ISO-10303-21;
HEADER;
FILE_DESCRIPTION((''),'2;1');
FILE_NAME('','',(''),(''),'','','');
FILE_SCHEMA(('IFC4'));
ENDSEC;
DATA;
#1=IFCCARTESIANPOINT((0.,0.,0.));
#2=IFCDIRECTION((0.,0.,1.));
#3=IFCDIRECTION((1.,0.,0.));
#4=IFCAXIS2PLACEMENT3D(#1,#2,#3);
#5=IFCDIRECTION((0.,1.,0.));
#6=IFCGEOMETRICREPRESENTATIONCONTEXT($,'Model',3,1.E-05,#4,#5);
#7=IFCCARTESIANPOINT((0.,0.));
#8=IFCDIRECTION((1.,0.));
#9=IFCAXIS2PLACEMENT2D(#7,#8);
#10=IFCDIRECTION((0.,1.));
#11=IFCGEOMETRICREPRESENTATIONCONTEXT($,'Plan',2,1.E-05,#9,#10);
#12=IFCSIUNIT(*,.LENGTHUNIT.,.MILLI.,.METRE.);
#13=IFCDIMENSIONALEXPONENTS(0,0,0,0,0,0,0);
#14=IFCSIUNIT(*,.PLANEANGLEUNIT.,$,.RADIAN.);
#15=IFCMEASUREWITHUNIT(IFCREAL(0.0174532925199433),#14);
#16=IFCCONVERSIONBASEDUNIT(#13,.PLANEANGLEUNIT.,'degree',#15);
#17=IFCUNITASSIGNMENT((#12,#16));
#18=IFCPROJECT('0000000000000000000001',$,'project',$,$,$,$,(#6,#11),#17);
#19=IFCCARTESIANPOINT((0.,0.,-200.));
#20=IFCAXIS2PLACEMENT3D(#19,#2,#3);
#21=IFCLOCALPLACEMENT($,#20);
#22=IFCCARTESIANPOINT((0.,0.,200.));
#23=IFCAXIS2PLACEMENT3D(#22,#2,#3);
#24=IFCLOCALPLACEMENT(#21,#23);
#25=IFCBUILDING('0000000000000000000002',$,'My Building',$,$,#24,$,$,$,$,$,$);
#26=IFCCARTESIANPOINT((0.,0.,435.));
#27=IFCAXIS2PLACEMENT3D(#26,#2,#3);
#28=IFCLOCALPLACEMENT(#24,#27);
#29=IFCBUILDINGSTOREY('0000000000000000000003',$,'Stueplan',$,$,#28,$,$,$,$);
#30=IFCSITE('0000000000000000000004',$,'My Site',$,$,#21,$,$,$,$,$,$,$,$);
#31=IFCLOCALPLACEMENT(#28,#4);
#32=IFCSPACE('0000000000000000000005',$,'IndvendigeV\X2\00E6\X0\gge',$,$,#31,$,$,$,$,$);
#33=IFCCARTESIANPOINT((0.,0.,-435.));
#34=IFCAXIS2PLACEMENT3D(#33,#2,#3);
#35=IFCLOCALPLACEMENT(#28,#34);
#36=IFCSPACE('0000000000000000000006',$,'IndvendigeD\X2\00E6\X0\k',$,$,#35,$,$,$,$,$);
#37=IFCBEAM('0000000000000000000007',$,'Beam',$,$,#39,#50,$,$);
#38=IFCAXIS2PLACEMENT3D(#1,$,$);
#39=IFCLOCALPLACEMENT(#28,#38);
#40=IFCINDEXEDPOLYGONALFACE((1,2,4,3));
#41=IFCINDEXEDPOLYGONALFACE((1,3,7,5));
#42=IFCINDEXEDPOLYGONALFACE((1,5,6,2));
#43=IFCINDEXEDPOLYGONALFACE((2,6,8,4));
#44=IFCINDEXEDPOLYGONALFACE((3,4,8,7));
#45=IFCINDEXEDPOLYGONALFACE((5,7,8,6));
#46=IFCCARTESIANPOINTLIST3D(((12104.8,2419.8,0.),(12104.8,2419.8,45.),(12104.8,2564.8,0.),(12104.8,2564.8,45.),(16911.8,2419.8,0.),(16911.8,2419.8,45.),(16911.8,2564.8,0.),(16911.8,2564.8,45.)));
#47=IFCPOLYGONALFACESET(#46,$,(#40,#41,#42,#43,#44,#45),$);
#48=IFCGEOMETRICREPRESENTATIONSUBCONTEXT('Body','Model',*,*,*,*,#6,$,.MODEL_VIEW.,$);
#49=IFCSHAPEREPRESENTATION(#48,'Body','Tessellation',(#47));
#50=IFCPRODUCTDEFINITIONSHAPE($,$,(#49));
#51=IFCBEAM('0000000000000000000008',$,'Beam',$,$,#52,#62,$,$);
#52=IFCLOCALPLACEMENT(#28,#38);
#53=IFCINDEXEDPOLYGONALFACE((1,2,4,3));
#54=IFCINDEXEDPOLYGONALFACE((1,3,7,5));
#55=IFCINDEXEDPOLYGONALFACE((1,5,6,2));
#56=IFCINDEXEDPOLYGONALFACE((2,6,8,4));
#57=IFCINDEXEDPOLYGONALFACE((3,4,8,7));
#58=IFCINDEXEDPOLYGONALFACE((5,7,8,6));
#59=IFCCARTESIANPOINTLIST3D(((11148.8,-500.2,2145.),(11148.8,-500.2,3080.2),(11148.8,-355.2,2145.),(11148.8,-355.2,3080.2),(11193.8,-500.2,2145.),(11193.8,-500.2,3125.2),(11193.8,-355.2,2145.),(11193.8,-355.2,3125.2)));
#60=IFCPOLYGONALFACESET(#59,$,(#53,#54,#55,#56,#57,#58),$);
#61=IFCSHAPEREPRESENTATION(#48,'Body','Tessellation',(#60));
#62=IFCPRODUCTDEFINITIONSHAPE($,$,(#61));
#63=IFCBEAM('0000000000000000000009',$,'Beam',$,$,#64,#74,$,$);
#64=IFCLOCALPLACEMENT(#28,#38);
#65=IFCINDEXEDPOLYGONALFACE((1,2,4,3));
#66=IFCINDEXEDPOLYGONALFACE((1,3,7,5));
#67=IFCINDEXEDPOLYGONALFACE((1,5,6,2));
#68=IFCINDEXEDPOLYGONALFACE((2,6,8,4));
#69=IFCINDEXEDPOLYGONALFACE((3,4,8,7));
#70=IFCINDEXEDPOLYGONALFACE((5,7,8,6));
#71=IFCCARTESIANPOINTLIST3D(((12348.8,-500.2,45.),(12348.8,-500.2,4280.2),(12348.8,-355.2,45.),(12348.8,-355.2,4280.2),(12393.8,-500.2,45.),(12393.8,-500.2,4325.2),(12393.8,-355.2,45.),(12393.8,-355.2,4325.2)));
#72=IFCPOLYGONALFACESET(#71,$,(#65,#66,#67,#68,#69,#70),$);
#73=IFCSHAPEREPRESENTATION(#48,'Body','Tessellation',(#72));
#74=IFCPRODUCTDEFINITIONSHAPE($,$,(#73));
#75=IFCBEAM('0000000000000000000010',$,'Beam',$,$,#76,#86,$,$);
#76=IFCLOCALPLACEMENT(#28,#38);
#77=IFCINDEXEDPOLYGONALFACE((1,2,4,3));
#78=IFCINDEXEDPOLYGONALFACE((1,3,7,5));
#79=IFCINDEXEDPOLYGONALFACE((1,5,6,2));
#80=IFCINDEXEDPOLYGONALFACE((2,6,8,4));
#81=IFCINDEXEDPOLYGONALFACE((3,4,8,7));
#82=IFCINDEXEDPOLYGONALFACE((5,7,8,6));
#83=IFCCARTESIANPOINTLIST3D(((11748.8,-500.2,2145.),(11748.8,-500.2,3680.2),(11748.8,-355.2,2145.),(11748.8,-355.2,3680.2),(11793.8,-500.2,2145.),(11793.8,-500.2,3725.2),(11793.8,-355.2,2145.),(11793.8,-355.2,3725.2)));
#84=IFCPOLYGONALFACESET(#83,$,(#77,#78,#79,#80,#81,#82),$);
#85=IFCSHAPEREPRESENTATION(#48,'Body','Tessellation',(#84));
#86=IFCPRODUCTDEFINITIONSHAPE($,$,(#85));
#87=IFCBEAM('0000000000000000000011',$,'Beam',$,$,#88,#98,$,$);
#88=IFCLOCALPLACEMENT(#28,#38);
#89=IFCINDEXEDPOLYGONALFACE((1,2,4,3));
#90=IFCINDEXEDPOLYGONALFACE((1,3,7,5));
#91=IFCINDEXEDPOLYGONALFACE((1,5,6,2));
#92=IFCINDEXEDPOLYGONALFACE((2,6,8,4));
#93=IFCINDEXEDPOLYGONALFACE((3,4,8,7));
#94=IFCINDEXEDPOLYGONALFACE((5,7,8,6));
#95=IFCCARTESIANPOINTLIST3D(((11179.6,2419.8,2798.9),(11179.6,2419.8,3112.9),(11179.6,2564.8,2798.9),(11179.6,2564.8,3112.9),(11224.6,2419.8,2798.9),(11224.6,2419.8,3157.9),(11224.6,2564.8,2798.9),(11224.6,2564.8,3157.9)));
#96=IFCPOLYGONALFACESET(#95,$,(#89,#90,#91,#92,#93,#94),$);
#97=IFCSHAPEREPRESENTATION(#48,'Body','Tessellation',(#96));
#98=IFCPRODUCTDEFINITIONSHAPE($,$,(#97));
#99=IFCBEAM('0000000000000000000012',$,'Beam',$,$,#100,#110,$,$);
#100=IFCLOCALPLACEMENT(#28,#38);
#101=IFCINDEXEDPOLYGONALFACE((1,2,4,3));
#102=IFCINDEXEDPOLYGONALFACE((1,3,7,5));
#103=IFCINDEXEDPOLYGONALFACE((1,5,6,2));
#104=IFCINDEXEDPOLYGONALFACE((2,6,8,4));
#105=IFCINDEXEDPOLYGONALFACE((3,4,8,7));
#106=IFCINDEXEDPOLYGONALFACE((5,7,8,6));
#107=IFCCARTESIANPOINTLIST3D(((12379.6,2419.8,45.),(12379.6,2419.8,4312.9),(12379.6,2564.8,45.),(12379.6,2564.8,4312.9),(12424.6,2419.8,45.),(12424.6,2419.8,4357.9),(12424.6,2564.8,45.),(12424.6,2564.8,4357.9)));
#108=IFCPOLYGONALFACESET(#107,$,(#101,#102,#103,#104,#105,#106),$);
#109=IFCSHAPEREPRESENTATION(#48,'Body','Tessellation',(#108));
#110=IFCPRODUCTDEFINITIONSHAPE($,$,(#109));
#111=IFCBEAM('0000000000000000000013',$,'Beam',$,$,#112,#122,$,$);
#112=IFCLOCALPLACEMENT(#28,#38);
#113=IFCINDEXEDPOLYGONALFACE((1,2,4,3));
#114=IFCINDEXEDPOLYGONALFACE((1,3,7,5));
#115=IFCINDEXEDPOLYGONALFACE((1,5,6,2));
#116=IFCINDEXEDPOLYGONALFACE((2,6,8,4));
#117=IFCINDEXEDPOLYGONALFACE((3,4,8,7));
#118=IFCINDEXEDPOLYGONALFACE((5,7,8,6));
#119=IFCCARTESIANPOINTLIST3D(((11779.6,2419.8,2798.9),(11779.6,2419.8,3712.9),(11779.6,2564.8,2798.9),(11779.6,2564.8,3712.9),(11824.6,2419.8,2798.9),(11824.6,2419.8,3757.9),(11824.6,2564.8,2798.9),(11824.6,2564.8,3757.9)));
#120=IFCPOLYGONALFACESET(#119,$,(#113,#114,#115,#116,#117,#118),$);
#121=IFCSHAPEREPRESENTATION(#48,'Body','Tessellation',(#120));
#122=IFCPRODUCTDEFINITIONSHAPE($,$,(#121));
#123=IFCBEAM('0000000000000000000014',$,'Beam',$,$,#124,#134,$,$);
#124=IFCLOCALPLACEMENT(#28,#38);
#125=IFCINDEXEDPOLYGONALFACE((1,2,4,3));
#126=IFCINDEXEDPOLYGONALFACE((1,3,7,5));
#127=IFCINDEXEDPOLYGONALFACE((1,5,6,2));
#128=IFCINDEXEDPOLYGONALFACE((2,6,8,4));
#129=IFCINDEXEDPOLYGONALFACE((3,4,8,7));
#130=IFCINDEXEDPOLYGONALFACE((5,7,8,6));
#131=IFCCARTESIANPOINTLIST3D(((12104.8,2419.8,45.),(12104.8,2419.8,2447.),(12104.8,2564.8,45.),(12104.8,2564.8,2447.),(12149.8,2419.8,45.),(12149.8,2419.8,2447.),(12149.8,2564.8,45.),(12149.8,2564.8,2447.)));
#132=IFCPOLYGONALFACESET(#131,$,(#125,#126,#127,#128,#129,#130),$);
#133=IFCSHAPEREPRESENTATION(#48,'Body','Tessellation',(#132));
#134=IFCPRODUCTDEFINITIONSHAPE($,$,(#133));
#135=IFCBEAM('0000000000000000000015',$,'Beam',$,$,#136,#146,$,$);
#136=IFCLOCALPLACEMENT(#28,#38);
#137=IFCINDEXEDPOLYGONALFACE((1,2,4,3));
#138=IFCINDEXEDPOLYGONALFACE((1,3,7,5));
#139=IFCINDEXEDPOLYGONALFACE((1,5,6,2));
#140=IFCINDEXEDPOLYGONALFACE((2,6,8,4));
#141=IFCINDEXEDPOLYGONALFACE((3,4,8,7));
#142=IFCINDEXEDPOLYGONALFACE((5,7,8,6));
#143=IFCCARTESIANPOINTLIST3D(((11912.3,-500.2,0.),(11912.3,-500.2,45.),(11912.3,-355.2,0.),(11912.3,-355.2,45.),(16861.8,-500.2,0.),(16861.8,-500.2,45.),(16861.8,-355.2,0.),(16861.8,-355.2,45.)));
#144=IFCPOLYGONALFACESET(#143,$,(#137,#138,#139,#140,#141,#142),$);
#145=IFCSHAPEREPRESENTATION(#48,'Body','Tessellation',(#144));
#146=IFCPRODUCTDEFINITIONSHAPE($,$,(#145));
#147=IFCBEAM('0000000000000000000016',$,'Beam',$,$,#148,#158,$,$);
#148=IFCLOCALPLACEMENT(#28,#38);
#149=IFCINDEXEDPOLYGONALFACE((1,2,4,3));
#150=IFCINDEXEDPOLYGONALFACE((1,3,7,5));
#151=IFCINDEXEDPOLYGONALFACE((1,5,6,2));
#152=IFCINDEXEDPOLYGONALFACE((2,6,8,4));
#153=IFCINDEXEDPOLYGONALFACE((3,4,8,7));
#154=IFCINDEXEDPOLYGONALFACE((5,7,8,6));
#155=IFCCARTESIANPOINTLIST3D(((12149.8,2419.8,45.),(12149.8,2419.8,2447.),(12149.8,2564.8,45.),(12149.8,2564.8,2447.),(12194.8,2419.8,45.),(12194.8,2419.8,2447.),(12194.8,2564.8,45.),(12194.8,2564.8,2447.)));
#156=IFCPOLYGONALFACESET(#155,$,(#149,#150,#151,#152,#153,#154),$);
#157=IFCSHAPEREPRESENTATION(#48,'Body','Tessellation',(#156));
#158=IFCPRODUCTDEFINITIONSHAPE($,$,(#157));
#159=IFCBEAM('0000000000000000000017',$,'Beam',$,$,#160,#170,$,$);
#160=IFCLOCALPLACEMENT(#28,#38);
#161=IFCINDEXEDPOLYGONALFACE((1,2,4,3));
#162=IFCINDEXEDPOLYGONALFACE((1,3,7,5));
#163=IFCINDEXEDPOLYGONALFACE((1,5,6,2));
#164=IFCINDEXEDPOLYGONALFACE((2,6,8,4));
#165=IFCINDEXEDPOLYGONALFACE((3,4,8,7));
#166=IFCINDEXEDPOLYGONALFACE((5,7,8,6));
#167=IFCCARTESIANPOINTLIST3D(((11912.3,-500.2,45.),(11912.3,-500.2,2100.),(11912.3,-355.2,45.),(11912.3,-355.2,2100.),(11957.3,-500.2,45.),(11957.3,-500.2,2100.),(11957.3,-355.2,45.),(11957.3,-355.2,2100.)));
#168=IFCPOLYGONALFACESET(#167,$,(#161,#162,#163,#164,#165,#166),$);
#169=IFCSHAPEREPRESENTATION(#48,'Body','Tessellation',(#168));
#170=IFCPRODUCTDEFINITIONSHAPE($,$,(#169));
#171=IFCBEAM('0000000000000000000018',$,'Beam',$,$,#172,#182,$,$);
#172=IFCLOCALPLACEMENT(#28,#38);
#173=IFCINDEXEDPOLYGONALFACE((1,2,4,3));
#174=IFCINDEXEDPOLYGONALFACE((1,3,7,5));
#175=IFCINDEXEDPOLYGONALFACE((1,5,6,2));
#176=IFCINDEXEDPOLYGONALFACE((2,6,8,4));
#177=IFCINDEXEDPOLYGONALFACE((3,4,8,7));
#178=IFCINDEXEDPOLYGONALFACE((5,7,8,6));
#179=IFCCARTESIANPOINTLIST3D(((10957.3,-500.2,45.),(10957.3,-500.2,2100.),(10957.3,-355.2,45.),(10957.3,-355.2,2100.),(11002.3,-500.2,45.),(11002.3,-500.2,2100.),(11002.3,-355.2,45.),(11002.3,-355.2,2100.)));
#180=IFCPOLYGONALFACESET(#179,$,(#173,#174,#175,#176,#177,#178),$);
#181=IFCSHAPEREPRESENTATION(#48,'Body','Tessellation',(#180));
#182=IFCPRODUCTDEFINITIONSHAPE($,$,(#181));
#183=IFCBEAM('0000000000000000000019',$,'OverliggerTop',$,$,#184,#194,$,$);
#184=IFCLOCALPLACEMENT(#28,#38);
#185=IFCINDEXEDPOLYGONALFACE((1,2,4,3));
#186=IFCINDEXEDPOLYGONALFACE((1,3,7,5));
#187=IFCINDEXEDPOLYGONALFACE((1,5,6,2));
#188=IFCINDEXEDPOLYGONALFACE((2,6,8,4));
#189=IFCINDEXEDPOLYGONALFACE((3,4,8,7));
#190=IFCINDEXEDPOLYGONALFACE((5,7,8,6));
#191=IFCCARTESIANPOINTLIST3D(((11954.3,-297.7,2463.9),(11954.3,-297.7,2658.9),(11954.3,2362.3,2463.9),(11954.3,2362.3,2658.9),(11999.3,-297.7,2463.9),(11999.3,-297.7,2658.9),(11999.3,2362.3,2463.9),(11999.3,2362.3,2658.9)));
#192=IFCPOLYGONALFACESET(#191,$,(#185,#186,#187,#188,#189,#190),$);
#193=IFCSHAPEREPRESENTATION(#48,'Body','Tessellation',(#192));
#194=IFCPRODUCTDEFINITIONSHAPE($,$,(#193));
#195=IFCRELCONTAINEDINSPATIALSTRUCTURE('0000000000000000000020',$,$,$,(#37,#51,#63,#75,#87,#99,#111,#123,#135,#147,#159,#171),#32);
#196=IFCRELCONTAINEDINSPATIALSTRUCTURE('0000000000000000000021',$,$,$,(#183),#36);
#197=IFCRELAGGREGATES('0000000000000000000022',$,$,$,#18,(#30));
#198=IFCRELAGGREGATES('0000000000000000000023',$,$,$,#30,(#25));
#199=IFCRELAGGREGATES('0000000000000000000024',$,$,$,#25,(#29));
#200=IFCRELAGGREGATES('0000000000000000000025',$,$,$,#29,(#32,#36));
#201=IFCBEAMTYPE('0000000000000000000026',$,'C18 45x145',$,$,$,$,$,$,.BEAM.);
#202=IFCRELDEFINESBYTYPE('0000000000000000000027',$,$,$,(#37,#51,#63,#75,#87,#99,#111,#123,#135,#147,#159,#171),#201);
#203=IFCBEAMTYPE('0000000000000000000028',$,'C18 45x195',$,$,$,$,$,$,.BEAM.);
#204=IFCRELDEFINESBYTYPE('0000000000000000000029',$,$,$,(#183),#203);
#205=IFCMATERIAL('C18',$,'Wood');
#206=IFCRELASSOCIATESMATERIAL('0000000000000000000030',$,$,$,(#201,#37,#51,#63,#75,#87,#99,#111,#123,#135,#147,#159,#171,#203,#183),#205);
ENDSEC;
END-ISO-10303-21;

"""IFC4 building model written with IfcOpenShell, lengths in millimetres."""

from ifc_helpers import new_model, entity, si_unit, converted_unit, direction, frame, origin_with_axes, origin_2d_with_axis, place, context, subcontext, project, spatial, rectangle, extrude, clip, halfspace, material, material_profile, profile_set, profile_usage, type_object, element, save


model = new_model("IFC4")

# Units and contexts
model_context = context("Model", 3, precision=1e-05, world=origin_with_axes(), true_north=direction((0.0, 1.0, 0.0)))
plan_context = context("Plan", 2, precision=1e-05, world=origin_2d_with_axis(), true_north=direction((0.0, 1.0)))
body_context_1 = subcontext(model_context, "Body", "Model", "MODEL_VIEW")
ifc_project = project(units=[si_unit("LENGTHUNIT", "METRE", prefix="MILLI"), converted_unit("PLANEANGLEUNIT", "degree", entity("IfcReal", 0.0174532925199433), si_unit("PLANEANGLEUNIT", "RADIAN"), dimensions=[0, 0, 0, 0, 0, 0, 0])], contexts=[model_context, plan_context])

# Site, building, storey
site_placement = place(None, frame((0.0, 0.0, -200.0), z_axis=(0.0, 0.0, 1.0), x_axis=(1.0, 0.0, 0.0)))
site = spatial("IfcSite", under=ifc_project, at=site_placement, Name="My Site")
building_placement = place(site_placement, frame((0.0, 0.0, 200.0), z_axis=(0.0, 0.0, 1.0), x_axis=(1.0, 0.0, 0.0)))
building = spatial("IfcBuilding", under=site, at=building_placement, Name="My Building")
storey_placement = place(building_placement, frame((0.0, 0.0, 435.0), z_axis=(0.0, 0.0, 1.0), x_axis=(1.0, 0.0, 0.0)))
storey = spatial("IfcBuildingStorey", under=building, at=storey_placement, Name="Stueplan")

# Shared definitions
ifc_material = material(Name="C18", Category="Wood")

# Shared definitions
space_1_placement = place(storey_placement, frame((0.0, 0.0, 0.0), z_axis=(0.0, 0.0, 1.0), x_axis=(1.0, 0.0, 0.0)))
space_1 = spatial("IfcSpace", under=storey, at=space_1_placement, Name="IndvendigeVægge")

# Beams
ifc_material_profile_1 = material_profile(ifc_material, rectangle(XDim=45.0, YDim=145.0))
ifc_profile_set_1 = profile_set([ifc_material_profile_1], Name="woodStructural")
ifc_profile_usage_1 = profile_usage(ifc_profile_set_1)
beam_type_1 = type_object("IfcBeamType", Name="C18 45x145", PredefinedType="BEAM", material=ifc_profile_set_1)
beam_1_placement = place(space_1_placement, frame((12104.8, 2492.3, 22.5), z_axis=(1.0, 0.0, 0.0), x_axis=(0.0, 0.0, 1.0)))
element("IfcBeam", 1, at=beam_1_placement, inside=space_1, type_object=beam_type_1, material=ifc_profile_usage_1, Name="Beam", context=body_context_1, shape_type="SweptSolid", body=[
    extrude(rectangle(XDim=45.0, YDim=145.0), origin_with_axes(), (0.0, 0.0, 1.0), 4807.0),
])
ifc_profile_usage_2 = profile_usage(ifc_profile_set_1)
beam_2_placement = place(space_1_placement, frame((11171.3, -427.7, 2145.0), z_axis=(0.0, 0.0, 1.0), x_axis=(-1.0, 0.0, 0.0)))
element("IfcBeam", 2, at=beam_2_placement, inside=space_1, type_object=beam_type_1, material=ifc_profile_usage_2, Name="Beam", context=body_context_1, shape_type="Clipping", body=[
    clip(extrude(rectangle(XDim=45.0, YDim=145.0), origin_with_axes(), (0.0, 0.0, 1.0), 1102.7), halfspace(frame((-2746.1, 0.0, 3703.8), z_axis=(0.707107, 0.0, 0.707107), x_axis=(0.0, -1.0, 0.0)), False)),
])
ifc_profile_usage_3 = profile_usage(ifc_profile_set_1)
beam_3_placement = place(space_1_placement, frame((12371.3, -427.7, 45.0), z_axis=(0.0, 0.0, 1.0), x_axis=(-1.0, 0.0, 0.0)))
element("IfcBeam", 3, at=beam_3_placement, inside=space_1, type_object=beam_type_1, material=ifc_profile_usage_3, Name="Beam", context=body_context_1, shape_type="Clipping", body=[
    clip(extrude(rectangle(XDim=45.0, YDim=145.0), origin_with_axes(), (0.0, 0.0, 1.0), 4402.7), halfspace(frame((-1546.1, 0.0, 5803.8), z_axis=(0.707107, 0.0, 0.707107), x_axis=(0.0, -1.0, 0.0)), False)),
])
ifc_profile_usage_4 = profile_usage(ifc_profile_set_1)
beam_4_placement = place(space_1_placement, frame((11771.3, -427.7, 2145.0), z_axis=(0.0, 0.0, 1.0), x_axis=(-1.0, 0.0, 0.0)))
element("IfcBeam", 4, at=beam_4_placement, inside=space_1, type_object=beam_type_1, material=ifc_profile_usage_4, Name="Beam", context=body_context_1, shape_type="Clipping", body=[
    clip(extrude(rectangle(XDim=45.0, YDim=145.0), origin_with_axes(), (0.0, 0.0, 1.0), 1702.7), halfspace(frame((-2146.1, 0.0, 3703.8), z_axis=(0.707107, 0.0, 0.707107), x_axis=(0.0, -1.0, 0.0)), False)),
])
ifc_profile_usage_5 = profile_usage(ifc_profile_set_1)
beam_5_placement = place(space_1_placement, frame((11202.1, 2492.3, 2798.9), z_axis=(0.0, 0.0, 1.0), x_axis=(-1.0, 0.0, 0.0)))
element("IfcBeam", 5, at=beam_5_placement, inside=space_1, type_object=beam_type_1, material=ifc_profile_usage_5, Name="Beam", context=body_context_1, shape_type="Clipping", body=[
    clip(extrude(rectangle(XDim=45.0, YDim=145.0), origin_with_axes(), (0.0, 0.0, 1.0), 481.4), halfspace(frame((-2712.8, 0.0, 3049.3), z_axis=(0.707107, 0.0, 0.707107), x_axis=(0.0, -1.0, 0.0)), False)),
])
ifc_profile_usage_6 = profile_usage(ifc_profile_set_1)
beam_6_placement = place(space_1_placement, frame((12402.1, 2492.3, 45.0), z_axis=(0.0, 0.0, 1.0), x_axis=(-1.0, 0.0, 0.0)))
element("IfcBeam", 6, at=beam_6_placement, inside=space_1, type_object=beam_type_1, material=ifc_profile_usage_6, Name="Beam", context=body_context_1, shape_type="Clipping", body=[
    clip(extrude(rectangle(XDim=45.0, YDim=145.0), origin_with_axes(), (0.0, 0.0, 1.0), 4435.4), halfspace(frame((-1439.0, 0.0, 5729.4), z_axis=(0.707107, 0.0, 0.707107), x_axis=(0.0, -1.0, 0.0)), False)),
])
ifc_profile_usage_7 = profile_usage(ifc_profile_set_1)
beam_7_placement = place(space_1_placement, frame((11802.1, 2492.3, 2798.9), z_axis=(0.0, 0.0, 1.0), x_axis=(-1.0, 0.0, 0.0)))
element("IfcBeam", 7, at=beam_7_placement, inside=space_1, type_object=beam_type_1, material=ifc_profile_usage_7, Name="Beam", context=body_context_1, shape_type="Clipping", body=[
    clip(extrude(rectangle(XDim=45.0, YDim=145.0), origin_with_axes(), (0.0, 0.0, 1.0), 1081.4), halfspace(frame((-2112.8, 0.0, 3049.3), z_axis=(0.707107, 0.0, 0.707107), x_axis=(0.0, -1.0, 0.0)), False)),
])
ifc_profile_usage_8 = profile_usage(ifc_profile_set_1)
beam_8_placement = place(space_1_placement, frame((12127.3, 2492.3, 45.0), z_axis=(0.0, 0.0, 1.0), x_axis=(-1.0, 0.0, 0.0)))
element("IfcBeam", 8, at=beam_8_placement, inside=space_1, type_object=beam_type_1, material=ifc_profile_usage_8, Name="Beam", context=body_context_1, shape_type="SweptSolid", body=[
    extrude(rectangle(XDim=45.0, YDim=145.0), origin_with_axes(), (0.0, 0.0, 1.0), 2402.0),
])
ifc_profile_usage_9 = profile_usage(ifc_profile_set_1)
beam_9_placement = place(space_1_placement, frame((11912.3, -427.7, 22.5), z_axis=(1.0, 0.0, 0.0), x_axis=(0.0, 0.0, 1.0)))
element("IfcBeam", 9, at=beam_9_placement, inside=space_1, type_object=beam_type_1, material=ifc_profile_usage_9, Name="Beam", context=body_context_1, shape_type="SweptSolid", body=[
    extrude(rectangle(XDim=45.0, YDim=145.0), origin_with_axes(), (0.0, 0.0, 1.0), 4949.5),
])
ifc_profile_usage_10 = profile_usage(ifc_profile_set_1)
beam_10_placement = place(space_1_placement, frame((12172.3, 2492.3, 45.0), z_axis=(0.0, 0.0, 1.0), x_axis=(-1.0, 0.0, 0.0)))
element("IfcBeam", 10, at=beam_10_placement, inside=space_1, type_object=beam_type_1, material=ifc_profile_usage_10, Name="Beam", context=body_context_1, shape_type="SweptSolid", body=[
    extrude(rectangle(XDim=45.0, YDim=145.0), origin_with_axes(), (0.0, 0.0, 1.0), 2402.0),
])
ifc_profile_usage_11 = profile_usage(ifc_profile_set_1)
beam_11_placement = place(space_1_placement, frame((11934.8, -427.7, 45.0), z_axis=(0.0, 0.0, 1.0), x_axis=(-1.0, 0.0, 0.0)))
element("IfcBeam", 11, at=beam_11_placement, inside=space_1, type_object=beam_type_1, material=ifc_profile_usage_11, Name="Beam", context=body_context_1, shape_type="SweptSolid", body=[
    extrude(rectangle(XDim=45.0, YDim=145.0), origin_with_axes(), (0.0, 0.0, 1.0), 2055.0),
])
ifc_profile_usage_12 = profile_usage(ifc_profile_set_1)
beam_12_placement = place(space_1_placement, frame((10979.8, -427.7, 45.0), z_axis=(0.0, 0.0, 1.0), x_axis=(-1.0, 0.0, 0.0)))
element("IfcBeam", 12, at=beam_12_placement, inside=space_1, type_object=beam_type_1, material=ifc_profile_usage_12, Name="Beam", context=body_context_1, shape_type="SweptSolid", body=[
    extrude(rectangle(XDim=45.0, YDim=145.0), origin_with_axes(), (0.0, 0.0, 1.0), 2055.0),
])

# Shared definitions
space_2_placement = place(storey_placement, frame((0.0, 0.0, -435.0), z_axis=(0.0, 0.0, 1.0), x_axis=(1.0, 0.0, 0.0)))
space_2 = spatial("IfcSpace", under=storey, at=space_2_placement, Name="IndvendigeDæk")

# Beam
ifc_material_profile_2 = material_profile(ifc_material, rectangle(XDim=45.0, YDim=195.0))
ifc_profile_set_2 = profile_set([ifc_material_profile_2], Name="woodStructural")
ifc_profile_usage_13 = profile_usage(ifc_profile_set_2)
beam_type_2 = type_object("IfcBeamType", Name="C18 45x195", PredefinedType="BEAM", material=ifc_profile_set_2)
beam_13_placement = place(space_2_placement, frame((11976.8, 2362.3, 2996.4), z_axis=(0.000001, -1.0, 0.0), x_axis=(-1.0, -0.000001, 0.0)))
element("IfcBeam", 13, at=beam_13_placement, inside=space_2, type_object=beam_type_2, material=ifc_profile_usage_13, Name="OverliggerTop", context=body_context_1, shape_type="SweptSolid", body=[
    extrude(rectangle(XDim=45.0, YDim=195.0), origin_with_axes(), (0.0, 0.0, 1.0), 2660.0),
])

save(model, "model.ifc")
